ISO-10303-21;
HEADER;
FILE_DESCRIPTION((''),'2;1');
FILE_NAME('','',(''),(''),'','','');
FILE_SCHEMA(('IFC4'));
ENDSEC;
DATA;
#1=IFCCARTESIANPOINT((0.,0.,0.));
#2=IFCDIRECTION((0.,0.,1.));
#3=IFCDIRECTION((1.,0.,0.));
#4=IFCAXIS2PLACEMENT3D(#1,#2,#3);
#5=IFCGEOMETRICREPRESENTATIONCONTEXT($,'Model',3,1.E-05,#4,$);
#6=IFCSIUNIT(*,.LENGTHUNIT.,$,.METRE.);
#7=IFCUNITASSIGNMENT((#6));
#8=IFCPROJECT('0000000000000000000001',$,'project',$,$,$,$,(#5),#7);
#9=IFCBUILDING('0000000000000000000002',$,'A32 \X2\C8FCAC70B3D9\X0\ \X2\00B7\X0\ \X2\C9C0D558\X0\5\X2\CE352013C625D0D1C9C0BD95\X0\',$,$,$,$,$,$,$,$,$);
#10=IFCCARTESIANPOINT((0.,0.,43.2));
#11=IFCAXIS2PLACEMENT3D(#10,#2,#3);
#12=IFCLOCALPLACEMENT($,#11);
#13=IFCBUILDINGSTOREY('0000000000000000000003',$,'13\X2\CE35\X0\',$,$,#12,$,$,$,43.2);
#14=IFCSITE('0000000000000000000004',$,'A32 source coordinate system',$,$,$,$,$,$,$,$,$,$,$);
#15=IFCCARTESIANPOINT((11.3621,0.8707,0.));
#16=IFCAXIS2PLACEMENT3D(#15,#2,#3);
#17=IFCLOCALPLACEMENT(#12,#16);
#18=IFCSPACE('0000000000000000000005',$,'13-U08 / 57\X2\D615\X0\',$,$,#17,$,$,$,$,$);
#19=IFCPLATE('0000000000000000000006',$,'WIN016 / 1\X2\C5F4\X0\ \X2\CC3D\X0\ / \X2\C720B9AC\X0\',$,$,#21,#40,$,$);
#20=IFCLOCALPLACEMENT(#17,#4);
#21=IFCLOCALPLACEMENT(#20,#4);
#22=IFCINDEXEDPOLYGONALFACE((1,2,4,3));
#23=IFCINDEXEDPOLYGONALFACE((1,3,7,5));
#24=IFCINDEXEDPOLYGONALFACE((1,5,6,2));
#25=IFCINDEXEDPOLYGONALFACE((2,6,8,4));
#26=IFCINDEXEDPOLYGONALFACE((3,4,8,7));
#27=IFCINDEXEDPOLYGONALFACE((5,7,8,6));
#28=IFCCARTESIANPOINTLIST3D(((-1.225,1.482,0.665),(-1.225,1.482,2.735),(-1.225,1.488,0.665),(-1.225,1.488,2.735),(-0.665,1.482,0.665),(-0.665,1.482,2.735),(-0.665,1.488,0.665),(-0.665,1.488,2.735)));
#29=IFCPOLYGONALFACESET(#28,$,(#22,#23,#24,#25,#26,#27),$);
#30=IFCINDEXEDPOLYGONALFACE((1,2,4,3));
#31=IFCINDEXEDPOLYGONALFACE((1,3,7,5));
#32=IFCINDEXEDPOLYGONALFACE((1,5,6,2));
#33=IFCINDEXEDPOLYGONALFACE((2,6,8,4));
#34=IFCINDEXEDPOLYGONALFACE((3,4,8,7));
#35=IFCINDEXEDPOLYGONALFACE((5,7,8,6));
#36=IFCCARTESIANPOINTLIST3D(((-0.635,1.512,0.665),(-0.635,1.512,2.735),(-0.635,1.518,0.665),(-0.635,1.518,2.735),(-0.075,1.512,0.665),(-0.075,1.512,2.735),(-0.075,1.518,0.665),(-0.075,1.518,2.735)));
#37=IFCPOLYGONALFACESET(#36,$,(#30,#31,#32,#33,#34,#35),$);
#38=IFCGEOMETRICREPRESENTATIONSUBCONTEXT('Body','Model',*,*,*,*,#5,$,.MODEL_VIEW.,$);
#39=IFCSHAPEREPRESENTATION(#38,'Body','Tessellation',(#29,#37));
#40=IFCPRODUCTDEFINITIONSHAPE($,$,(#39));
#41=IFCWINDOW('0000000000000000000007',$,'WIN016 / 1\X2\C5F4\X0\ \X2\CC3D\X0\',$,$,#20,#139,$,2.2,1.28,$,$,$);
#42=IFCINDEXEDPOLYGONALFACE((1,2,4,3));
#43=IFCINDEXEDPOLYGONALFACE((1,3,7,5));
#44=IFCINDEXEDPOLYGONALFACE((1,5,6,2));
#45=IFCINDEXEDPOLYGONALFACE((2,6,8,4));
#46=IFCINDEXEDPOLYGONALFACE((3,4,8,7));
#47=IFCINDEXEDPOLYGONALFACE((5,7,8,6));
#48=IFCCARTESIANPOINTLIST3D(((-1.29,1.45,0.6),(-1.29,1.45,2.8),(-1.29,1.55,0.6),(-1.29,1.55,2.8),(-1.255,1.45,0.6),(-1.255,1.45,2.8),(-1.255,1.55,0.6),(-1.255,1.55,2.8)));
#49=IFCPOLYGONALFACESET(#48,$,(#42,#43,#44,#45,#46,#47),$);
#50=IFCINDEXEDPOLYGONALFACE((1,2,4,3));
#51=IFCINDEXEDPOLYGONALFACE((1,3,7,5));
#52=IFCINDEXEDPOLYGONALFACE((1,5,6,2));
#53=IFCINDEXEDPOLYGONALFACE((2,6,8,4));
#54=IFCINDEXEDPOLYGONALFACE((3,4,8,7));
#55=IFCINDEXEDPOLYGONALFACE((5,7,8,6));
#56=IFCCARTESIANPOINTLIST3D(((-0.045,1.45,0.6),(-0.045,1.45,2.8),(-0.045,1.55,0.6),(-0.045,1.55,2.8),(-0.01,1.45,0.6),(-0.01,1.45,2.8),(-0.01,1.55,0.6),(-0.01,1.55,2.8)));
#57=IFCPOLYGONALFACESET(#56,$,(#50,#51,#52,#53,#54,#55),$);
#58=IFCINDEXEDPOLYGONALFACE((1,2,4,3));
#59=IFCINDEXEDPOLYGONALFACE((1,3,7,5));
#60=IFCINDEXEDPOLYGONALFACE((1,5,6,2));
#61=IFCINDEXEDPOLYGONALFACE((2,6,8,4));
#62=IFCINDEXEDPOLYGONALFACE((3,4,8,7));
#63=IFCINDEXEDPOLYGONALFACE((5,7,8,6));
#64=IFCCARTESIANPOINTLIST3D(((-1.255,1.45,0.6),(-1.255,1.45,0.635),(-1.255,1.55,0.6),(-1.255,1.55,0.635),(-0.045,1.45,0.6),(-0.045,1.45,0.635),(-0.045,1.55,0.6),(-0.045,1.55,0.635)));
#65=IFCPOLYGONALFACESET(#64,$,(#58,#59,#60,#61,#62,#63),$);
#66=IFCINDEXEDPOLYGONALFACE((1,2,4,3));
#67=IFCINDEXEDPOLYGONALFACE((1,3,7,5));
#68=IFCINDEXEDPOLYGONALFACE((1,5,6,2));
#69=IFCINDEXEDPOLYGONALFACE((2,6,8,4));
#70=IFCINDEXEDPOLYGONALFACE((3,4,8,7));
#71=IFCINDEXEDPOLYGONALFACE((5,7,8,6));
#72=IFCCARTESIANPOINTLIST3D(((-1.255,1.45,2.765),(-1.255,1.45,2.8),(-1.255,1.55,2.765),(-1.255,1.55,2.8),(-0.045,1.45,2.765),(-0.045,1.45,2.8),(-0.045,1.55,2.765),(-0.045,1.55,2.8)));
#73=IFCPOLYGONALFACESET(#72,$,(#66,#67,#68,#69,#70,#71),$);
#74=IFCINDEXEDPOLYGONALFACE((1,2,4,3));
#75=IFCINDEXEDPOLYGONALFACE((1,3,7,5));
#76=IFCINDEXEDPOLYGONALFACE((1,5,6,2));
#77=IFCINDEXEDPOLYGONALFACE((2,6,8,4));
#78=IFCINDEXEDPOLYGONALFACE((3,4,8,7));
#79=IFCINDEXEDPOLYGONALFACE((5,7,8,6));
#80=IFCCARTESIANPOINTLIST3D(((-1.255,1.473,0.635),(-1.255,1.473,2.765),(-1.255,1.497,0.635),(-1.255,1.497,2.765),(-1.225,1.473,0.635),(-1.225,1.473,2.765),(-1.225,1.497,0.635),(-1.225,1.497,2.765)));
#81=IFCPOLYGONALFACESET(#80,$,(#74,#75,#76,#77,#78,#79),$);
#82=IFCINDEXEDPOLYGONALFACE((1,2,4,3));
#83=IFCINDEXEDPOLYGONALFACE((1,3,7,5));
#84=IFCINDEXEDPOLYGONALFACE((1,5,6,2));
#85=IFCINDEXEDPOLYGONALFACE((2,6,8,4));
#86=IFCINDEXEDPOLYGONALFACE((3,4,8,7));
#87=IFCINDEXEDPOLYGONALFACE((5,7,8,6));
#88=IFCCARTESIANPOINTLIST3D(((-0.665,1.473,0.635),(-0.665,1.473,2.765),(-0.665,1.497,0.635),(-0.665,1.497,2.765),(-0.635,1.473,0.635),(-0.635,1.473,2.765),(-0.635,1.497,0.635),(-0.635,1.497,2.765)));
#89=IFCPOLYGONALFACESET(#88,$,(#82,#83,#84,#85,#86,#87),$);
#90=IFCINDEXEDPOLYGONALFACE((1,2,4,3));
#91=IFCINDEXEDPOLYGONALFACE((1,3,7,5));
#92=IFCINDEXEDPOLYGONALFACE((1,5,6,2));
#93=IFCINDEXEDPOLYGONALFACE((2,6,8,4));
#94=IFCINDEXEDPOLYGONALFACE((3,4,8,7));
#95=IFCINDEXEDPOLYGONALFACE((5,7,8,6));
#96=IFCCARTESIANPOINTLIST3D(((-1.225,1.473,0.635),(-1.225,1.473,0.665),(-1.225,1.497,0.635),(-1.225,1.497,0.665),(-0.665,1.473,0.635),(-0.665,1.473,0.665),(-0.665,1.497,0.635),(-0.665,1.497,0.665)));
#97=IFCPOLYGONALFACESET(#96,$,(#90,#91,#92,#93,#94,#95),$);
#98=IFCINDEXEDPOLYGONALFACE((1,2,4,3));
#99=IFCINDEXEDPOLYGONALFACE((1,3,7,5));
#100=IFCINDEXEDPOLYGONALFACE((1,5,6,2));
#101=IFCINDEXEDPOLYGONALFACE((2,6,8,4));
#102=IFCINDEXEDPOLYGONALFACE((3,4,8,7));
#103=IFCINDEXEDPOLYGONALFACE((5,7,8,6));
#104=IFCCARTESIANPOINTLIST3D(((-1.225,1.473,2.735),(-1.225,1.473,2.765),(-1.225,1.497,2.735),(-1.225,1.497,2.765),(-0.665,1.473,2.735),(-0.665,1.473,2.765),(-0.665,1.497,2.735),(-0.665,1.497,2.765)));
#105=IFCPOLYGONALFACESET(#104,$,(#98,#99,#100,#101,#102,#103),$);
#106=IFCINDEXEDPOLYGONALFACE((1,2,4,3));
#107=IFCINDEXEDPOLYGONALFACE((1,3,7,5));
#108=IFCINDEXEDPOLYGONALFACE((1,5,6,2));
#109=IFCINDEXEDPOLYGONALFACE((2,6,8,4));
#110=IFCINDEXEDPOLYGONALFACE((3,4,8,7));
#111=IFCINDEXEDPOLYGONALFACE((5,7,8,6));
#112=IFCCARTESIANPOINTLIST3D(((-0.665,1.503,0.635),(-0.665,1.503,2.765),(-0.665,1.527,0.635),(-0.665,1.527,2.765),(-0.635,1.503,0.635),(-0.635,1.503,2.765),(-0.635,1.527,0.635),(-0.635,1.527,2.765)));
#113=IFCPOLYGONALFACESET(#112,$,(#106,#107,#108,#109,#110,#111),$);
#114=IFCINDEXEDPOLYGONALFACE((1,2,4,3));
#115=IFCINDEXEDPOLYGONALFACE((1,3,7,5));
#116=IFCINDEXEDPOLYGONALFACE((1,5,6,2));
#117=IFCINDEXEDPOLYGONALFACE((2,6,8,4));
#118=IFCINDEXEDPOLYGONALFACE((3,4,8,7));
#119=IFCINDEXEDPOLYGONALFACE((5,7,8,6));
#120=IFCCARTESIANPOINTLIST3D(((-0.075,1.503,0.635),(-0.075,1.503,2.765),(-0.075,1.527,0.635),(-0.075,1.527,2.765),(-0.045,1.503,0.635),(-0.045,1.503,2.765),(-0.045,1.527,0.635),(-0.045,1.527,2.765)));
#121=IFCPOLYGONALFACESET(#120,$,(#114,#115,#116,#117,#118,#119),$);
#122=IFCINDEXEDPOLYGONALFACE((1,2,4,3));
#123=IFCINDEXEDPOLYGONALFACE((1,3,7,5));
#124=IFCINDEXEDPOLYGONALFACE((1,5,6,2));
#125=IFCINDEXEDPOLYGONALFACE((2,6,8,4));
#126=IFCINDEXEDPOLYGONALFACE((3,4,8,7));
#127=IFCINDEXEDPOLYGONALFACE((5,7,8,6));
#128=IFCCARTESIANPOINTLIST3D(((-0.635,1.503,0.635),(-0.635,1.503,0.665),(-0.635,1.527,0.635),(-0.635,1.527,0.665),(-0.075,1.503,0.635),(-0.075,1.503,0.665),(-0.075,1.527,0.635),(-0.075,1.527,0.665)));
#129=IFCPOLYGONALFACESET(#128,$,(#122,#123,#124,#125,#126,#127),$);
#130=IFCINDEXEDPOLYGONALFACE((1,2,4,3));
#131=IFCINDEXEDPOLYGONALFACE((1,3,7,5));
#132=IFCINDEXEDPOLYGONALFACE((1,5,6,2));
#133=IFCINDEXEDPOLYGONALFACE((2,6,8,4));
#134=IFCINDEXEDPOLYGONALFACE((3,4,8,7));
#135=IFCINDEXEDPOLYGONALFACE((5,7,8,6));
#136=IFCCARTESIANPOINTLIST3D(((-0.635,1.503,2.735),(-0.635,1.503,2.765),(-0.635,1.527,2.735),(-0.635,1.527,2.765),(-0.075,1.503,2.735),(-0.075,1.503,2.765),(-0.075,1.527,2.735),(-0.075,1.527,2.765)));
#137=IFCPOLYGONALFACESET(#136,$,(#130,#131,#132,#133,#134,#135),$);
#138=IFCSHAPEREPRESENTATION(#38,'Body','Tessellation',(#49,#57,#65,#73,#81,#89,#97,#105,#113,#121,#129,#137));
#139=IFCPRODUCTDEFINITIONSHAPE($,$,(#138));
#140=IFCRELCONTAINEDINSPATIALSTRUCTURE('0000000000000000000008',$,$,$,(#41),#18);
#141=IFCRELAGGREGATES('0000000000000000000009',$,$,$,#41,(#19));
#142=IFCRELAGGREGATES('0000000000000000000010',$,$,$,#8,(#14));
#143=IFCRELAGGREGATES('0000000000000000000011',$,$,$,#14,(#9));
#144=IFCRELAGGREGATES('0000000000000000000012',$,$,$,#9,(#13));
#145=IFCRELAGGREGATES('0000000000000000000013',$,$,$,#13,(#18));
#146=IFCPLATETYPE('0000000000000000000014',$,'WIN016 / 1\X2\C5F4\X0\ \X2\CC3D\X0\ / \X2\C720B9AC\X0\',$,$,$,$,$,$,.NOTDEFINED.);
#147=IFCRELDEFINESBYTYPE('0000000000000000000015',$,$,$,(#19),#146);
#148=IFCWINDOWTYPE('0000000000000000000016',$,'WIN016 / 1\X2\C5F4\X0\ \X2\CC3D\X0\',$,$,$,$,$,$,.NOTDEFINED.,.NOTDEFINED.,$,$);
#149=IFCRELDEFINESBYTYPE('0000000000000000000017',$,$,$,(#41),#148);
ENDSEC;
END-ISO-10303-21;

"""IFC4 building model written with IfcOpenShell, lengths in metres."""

from ifc_helpers import new_model, si_unit, frame, origin, origin_with_axes, place, context, subcontext, project, spatial, polyline, outline, extrude, source, transform, mapped, type_object, type_shapes, element, aggregate, save


model = new_model("IFC4")

# Units and contexts
model_context = context("Model", 3, precision=1e-05, world=origin_with_axes())
body_context = subcontext(model_context, "Body", "Model", "MODEL_VIEW")
ifc_project = project(units=[si_unit("LENGTHUNIT", "METRE")], contexts=[model_context])

# Plate
storey_placement = place(None, frame((0.0, 0.0, 43.2), z_axis=(0.0, 0.0, 1.0), x_axis=(1.0, 0.0, 0.0)))
space_placement = place(storey_placement, frame((11.3621, 0.8707, 0.0), z_axis=(0.0, 0.0, 1.0), x_axis=(1.0, 0.0, 0.0)))
plate_type_1 = type_object("IfcPlateType", Name="WIN016 / 1열 창 / 유리", PredefinedType="NOTDEFINED")
shared_shape_1 = source(origin(), body_context, "Body", "SweptSolid", [
    extrude(outline(polyline([(-1.225, 1.482), (-1.225, 1.488), (-0.665, 1.488), (-0.665, 1.482), (-1.225, 1.482)])), frame((0.0, 0.0, 0.665)), (0.0, 0.0, 1.0), 2.07),
    extrude(outline(polyline([(-0.635, 1.512), (-0.635, 1.518), (-0.075, 1.518), (-0.075, 1.512), (-0.635, 1.512)])), frame((0.0, 0.0, 0.665)), (0.0, 0.0, 1.0), 2.07),
])
type_shapes(plate_type_1, [shared_shape_1])
window_1_placement = place(space_placement, origin_with_axes())
plate_1_placement = place(window_1_placement, origin_with_axes())
plate_1 = element("IfcPlate", 1, at=plate_1_placement, type_object=plate_type_1, Name="WIN016 / 1열 창 / 유리", context=body_context, shape_type="MappedRepresentation", body=[
    mapped(shared_shape_1, transform((0.0, 0.0, 0.0), scale=1.0)),
])

# Site, building, storey, space
site = spatial("IfcSite", under=ifc_project, Name="A32 source coordinate system")
building = spatial("IfcBuilding", under=site, Name="A32 주거동 · 지하5층–옥탑지붕")
storey = spatial("IfcBuildingStorey", under=building, at=storey_placement, Name="13층", Elevation=43.2)
space = spatial("IfcSpace", under=storey, at=space_placement, Name="13-U08 / 57형")

# Window
window_type_1 = type_object("IfcWindowType", Name="WIN016 / 1열 창", PartitioningType="NOTDEFINED", PredefinedType="NOTDEFINED")
shared_shape_2 = source(origin(), body_context, "Body", "SweptSolid", [
    extrude(outline(polyline([(-1.29, 1.45), (-1.29, 1.55), (-1.255, 1.55), (-1.255, 1.45), (-1.29, 1.45)])), frame((0.0, 0.0, 0.6)), (0.0, 0.0, 1.0), 2.2),
    extrude(outline(polyline([(-0.045, 1.45), (-0.045, 1.55), (-0.01, 1.55), (-0.01, 1.45), (-0.045, 1.45)])), frame((0.0, 0.0, 0.6)), (0.0, 0.0, 1.0), 2.2),
    extrude(outline(polyline([(-1.255, 1.45), (-1.255, 1.55), (-0.045, 1.55), (-0.045, 1.45), (-1.255, 1.45)])), frame((0.0, 0.0, 0.6)), (0.0, 0.0, 1.0), 0.035),
    extrude(outline(polyline([(-1.255, 1.45), (-1.255, 1.55), (-0.045, 1.55), (-0.045, 1.45), (-1.255, 1.45)])), frame((0.0, 0.0, 2.765)), (0.0, 0.0, 1.0), 0.035),
    extrude(outline(polyline([(-1.255, 1.473), (-1.255, 1.497), (-1.225, 1.497), (-1.225, 1.473), (-1.255, 1.473)])), frame((0.0, 0.0, 0.635)), (0.0, 0.0, 1.0), 2.13),
    extrude(outline(polyline([(-0.665, 1.473), (-0.665, 1.497), (-0.635, 1.497), (-0.635, 1.473), (-0.665, 1.473)])), frame((0.0, 0.0, 0.635)), (0.0, 0.0, 1.0), 2.13),
    extrude(outline(polyline([(-1.225, 1.473), (-1.225, 1.497), (-0.665, 1.497), (-0.665, 1.473), (-1.225, 1.473)])), frame((0.0, 0.0, 0.635)), (0.0, 0.0, 1.0), 0.03),
    extrude(outline(polyline([(-1.225, 1.473), (-1.225, 1.497), (-0.665, 1.497), (-0.665, 1.473), (-1.225, 1.473)])), frame((0.0, 0.0, 2.735)), (0.0, 0.0, 1.0), 0.03),
    extrude(outline(polyline([(-0.665, 1.503), (-0.665, 1.527), (-0.635, 1.527), (-0.635, 1.503), (-0.665, 1.503)])), frame((0.0, 0.0, 0.635)), (0.0, 0.0, 1.0), 2.13),
    extrude(outline(polyline([(-0.075, 1.503), (-0.075, 1.527), (-0.045, 1.527), (-0.045, 1.503), (-0.075, 1.503)])), frame((0.0, 0.0, 0.635)), (0.0, 0.0, 1.0), 2.13),
    extrude(outline(polyline([(-0.635, 1.503), (-0.635, 1.527), (-0.075, 1.527), (-0.075, 1.503), (-0.635, 1.503)])), frame((0.0, 0.0, 0.635)), (0.0, 0.0, 1.0), 0.03),
    extrude(outline(polyline([(-0.635, 1.503), (-0.635, 1.527), (-0.075, 1.527), (-0.075, 1.503), (-0.635, 1.503)])), frame((0.0, 0.0, 2.735)), (0.0, 0.0, 1.0), 0.03),
])
type_shapes(window_type_1, [shared_shape_2])
window_1 = element("IfcWindow", 2, at=window_1_placement, inside=space, type_object=window_type_1, Name="WIN016 / 1열 창", OverallHeight=2.2, OverallWidth=1.28, context=body_context, shape_type="MappedRepresentation", body=[
    mapped(shared_shape_2, transform((0.0, 0.0, 0.0), scale=1.0)),
])
aggregate(window_1, [plate_1])

save(model, "model.ifc")
